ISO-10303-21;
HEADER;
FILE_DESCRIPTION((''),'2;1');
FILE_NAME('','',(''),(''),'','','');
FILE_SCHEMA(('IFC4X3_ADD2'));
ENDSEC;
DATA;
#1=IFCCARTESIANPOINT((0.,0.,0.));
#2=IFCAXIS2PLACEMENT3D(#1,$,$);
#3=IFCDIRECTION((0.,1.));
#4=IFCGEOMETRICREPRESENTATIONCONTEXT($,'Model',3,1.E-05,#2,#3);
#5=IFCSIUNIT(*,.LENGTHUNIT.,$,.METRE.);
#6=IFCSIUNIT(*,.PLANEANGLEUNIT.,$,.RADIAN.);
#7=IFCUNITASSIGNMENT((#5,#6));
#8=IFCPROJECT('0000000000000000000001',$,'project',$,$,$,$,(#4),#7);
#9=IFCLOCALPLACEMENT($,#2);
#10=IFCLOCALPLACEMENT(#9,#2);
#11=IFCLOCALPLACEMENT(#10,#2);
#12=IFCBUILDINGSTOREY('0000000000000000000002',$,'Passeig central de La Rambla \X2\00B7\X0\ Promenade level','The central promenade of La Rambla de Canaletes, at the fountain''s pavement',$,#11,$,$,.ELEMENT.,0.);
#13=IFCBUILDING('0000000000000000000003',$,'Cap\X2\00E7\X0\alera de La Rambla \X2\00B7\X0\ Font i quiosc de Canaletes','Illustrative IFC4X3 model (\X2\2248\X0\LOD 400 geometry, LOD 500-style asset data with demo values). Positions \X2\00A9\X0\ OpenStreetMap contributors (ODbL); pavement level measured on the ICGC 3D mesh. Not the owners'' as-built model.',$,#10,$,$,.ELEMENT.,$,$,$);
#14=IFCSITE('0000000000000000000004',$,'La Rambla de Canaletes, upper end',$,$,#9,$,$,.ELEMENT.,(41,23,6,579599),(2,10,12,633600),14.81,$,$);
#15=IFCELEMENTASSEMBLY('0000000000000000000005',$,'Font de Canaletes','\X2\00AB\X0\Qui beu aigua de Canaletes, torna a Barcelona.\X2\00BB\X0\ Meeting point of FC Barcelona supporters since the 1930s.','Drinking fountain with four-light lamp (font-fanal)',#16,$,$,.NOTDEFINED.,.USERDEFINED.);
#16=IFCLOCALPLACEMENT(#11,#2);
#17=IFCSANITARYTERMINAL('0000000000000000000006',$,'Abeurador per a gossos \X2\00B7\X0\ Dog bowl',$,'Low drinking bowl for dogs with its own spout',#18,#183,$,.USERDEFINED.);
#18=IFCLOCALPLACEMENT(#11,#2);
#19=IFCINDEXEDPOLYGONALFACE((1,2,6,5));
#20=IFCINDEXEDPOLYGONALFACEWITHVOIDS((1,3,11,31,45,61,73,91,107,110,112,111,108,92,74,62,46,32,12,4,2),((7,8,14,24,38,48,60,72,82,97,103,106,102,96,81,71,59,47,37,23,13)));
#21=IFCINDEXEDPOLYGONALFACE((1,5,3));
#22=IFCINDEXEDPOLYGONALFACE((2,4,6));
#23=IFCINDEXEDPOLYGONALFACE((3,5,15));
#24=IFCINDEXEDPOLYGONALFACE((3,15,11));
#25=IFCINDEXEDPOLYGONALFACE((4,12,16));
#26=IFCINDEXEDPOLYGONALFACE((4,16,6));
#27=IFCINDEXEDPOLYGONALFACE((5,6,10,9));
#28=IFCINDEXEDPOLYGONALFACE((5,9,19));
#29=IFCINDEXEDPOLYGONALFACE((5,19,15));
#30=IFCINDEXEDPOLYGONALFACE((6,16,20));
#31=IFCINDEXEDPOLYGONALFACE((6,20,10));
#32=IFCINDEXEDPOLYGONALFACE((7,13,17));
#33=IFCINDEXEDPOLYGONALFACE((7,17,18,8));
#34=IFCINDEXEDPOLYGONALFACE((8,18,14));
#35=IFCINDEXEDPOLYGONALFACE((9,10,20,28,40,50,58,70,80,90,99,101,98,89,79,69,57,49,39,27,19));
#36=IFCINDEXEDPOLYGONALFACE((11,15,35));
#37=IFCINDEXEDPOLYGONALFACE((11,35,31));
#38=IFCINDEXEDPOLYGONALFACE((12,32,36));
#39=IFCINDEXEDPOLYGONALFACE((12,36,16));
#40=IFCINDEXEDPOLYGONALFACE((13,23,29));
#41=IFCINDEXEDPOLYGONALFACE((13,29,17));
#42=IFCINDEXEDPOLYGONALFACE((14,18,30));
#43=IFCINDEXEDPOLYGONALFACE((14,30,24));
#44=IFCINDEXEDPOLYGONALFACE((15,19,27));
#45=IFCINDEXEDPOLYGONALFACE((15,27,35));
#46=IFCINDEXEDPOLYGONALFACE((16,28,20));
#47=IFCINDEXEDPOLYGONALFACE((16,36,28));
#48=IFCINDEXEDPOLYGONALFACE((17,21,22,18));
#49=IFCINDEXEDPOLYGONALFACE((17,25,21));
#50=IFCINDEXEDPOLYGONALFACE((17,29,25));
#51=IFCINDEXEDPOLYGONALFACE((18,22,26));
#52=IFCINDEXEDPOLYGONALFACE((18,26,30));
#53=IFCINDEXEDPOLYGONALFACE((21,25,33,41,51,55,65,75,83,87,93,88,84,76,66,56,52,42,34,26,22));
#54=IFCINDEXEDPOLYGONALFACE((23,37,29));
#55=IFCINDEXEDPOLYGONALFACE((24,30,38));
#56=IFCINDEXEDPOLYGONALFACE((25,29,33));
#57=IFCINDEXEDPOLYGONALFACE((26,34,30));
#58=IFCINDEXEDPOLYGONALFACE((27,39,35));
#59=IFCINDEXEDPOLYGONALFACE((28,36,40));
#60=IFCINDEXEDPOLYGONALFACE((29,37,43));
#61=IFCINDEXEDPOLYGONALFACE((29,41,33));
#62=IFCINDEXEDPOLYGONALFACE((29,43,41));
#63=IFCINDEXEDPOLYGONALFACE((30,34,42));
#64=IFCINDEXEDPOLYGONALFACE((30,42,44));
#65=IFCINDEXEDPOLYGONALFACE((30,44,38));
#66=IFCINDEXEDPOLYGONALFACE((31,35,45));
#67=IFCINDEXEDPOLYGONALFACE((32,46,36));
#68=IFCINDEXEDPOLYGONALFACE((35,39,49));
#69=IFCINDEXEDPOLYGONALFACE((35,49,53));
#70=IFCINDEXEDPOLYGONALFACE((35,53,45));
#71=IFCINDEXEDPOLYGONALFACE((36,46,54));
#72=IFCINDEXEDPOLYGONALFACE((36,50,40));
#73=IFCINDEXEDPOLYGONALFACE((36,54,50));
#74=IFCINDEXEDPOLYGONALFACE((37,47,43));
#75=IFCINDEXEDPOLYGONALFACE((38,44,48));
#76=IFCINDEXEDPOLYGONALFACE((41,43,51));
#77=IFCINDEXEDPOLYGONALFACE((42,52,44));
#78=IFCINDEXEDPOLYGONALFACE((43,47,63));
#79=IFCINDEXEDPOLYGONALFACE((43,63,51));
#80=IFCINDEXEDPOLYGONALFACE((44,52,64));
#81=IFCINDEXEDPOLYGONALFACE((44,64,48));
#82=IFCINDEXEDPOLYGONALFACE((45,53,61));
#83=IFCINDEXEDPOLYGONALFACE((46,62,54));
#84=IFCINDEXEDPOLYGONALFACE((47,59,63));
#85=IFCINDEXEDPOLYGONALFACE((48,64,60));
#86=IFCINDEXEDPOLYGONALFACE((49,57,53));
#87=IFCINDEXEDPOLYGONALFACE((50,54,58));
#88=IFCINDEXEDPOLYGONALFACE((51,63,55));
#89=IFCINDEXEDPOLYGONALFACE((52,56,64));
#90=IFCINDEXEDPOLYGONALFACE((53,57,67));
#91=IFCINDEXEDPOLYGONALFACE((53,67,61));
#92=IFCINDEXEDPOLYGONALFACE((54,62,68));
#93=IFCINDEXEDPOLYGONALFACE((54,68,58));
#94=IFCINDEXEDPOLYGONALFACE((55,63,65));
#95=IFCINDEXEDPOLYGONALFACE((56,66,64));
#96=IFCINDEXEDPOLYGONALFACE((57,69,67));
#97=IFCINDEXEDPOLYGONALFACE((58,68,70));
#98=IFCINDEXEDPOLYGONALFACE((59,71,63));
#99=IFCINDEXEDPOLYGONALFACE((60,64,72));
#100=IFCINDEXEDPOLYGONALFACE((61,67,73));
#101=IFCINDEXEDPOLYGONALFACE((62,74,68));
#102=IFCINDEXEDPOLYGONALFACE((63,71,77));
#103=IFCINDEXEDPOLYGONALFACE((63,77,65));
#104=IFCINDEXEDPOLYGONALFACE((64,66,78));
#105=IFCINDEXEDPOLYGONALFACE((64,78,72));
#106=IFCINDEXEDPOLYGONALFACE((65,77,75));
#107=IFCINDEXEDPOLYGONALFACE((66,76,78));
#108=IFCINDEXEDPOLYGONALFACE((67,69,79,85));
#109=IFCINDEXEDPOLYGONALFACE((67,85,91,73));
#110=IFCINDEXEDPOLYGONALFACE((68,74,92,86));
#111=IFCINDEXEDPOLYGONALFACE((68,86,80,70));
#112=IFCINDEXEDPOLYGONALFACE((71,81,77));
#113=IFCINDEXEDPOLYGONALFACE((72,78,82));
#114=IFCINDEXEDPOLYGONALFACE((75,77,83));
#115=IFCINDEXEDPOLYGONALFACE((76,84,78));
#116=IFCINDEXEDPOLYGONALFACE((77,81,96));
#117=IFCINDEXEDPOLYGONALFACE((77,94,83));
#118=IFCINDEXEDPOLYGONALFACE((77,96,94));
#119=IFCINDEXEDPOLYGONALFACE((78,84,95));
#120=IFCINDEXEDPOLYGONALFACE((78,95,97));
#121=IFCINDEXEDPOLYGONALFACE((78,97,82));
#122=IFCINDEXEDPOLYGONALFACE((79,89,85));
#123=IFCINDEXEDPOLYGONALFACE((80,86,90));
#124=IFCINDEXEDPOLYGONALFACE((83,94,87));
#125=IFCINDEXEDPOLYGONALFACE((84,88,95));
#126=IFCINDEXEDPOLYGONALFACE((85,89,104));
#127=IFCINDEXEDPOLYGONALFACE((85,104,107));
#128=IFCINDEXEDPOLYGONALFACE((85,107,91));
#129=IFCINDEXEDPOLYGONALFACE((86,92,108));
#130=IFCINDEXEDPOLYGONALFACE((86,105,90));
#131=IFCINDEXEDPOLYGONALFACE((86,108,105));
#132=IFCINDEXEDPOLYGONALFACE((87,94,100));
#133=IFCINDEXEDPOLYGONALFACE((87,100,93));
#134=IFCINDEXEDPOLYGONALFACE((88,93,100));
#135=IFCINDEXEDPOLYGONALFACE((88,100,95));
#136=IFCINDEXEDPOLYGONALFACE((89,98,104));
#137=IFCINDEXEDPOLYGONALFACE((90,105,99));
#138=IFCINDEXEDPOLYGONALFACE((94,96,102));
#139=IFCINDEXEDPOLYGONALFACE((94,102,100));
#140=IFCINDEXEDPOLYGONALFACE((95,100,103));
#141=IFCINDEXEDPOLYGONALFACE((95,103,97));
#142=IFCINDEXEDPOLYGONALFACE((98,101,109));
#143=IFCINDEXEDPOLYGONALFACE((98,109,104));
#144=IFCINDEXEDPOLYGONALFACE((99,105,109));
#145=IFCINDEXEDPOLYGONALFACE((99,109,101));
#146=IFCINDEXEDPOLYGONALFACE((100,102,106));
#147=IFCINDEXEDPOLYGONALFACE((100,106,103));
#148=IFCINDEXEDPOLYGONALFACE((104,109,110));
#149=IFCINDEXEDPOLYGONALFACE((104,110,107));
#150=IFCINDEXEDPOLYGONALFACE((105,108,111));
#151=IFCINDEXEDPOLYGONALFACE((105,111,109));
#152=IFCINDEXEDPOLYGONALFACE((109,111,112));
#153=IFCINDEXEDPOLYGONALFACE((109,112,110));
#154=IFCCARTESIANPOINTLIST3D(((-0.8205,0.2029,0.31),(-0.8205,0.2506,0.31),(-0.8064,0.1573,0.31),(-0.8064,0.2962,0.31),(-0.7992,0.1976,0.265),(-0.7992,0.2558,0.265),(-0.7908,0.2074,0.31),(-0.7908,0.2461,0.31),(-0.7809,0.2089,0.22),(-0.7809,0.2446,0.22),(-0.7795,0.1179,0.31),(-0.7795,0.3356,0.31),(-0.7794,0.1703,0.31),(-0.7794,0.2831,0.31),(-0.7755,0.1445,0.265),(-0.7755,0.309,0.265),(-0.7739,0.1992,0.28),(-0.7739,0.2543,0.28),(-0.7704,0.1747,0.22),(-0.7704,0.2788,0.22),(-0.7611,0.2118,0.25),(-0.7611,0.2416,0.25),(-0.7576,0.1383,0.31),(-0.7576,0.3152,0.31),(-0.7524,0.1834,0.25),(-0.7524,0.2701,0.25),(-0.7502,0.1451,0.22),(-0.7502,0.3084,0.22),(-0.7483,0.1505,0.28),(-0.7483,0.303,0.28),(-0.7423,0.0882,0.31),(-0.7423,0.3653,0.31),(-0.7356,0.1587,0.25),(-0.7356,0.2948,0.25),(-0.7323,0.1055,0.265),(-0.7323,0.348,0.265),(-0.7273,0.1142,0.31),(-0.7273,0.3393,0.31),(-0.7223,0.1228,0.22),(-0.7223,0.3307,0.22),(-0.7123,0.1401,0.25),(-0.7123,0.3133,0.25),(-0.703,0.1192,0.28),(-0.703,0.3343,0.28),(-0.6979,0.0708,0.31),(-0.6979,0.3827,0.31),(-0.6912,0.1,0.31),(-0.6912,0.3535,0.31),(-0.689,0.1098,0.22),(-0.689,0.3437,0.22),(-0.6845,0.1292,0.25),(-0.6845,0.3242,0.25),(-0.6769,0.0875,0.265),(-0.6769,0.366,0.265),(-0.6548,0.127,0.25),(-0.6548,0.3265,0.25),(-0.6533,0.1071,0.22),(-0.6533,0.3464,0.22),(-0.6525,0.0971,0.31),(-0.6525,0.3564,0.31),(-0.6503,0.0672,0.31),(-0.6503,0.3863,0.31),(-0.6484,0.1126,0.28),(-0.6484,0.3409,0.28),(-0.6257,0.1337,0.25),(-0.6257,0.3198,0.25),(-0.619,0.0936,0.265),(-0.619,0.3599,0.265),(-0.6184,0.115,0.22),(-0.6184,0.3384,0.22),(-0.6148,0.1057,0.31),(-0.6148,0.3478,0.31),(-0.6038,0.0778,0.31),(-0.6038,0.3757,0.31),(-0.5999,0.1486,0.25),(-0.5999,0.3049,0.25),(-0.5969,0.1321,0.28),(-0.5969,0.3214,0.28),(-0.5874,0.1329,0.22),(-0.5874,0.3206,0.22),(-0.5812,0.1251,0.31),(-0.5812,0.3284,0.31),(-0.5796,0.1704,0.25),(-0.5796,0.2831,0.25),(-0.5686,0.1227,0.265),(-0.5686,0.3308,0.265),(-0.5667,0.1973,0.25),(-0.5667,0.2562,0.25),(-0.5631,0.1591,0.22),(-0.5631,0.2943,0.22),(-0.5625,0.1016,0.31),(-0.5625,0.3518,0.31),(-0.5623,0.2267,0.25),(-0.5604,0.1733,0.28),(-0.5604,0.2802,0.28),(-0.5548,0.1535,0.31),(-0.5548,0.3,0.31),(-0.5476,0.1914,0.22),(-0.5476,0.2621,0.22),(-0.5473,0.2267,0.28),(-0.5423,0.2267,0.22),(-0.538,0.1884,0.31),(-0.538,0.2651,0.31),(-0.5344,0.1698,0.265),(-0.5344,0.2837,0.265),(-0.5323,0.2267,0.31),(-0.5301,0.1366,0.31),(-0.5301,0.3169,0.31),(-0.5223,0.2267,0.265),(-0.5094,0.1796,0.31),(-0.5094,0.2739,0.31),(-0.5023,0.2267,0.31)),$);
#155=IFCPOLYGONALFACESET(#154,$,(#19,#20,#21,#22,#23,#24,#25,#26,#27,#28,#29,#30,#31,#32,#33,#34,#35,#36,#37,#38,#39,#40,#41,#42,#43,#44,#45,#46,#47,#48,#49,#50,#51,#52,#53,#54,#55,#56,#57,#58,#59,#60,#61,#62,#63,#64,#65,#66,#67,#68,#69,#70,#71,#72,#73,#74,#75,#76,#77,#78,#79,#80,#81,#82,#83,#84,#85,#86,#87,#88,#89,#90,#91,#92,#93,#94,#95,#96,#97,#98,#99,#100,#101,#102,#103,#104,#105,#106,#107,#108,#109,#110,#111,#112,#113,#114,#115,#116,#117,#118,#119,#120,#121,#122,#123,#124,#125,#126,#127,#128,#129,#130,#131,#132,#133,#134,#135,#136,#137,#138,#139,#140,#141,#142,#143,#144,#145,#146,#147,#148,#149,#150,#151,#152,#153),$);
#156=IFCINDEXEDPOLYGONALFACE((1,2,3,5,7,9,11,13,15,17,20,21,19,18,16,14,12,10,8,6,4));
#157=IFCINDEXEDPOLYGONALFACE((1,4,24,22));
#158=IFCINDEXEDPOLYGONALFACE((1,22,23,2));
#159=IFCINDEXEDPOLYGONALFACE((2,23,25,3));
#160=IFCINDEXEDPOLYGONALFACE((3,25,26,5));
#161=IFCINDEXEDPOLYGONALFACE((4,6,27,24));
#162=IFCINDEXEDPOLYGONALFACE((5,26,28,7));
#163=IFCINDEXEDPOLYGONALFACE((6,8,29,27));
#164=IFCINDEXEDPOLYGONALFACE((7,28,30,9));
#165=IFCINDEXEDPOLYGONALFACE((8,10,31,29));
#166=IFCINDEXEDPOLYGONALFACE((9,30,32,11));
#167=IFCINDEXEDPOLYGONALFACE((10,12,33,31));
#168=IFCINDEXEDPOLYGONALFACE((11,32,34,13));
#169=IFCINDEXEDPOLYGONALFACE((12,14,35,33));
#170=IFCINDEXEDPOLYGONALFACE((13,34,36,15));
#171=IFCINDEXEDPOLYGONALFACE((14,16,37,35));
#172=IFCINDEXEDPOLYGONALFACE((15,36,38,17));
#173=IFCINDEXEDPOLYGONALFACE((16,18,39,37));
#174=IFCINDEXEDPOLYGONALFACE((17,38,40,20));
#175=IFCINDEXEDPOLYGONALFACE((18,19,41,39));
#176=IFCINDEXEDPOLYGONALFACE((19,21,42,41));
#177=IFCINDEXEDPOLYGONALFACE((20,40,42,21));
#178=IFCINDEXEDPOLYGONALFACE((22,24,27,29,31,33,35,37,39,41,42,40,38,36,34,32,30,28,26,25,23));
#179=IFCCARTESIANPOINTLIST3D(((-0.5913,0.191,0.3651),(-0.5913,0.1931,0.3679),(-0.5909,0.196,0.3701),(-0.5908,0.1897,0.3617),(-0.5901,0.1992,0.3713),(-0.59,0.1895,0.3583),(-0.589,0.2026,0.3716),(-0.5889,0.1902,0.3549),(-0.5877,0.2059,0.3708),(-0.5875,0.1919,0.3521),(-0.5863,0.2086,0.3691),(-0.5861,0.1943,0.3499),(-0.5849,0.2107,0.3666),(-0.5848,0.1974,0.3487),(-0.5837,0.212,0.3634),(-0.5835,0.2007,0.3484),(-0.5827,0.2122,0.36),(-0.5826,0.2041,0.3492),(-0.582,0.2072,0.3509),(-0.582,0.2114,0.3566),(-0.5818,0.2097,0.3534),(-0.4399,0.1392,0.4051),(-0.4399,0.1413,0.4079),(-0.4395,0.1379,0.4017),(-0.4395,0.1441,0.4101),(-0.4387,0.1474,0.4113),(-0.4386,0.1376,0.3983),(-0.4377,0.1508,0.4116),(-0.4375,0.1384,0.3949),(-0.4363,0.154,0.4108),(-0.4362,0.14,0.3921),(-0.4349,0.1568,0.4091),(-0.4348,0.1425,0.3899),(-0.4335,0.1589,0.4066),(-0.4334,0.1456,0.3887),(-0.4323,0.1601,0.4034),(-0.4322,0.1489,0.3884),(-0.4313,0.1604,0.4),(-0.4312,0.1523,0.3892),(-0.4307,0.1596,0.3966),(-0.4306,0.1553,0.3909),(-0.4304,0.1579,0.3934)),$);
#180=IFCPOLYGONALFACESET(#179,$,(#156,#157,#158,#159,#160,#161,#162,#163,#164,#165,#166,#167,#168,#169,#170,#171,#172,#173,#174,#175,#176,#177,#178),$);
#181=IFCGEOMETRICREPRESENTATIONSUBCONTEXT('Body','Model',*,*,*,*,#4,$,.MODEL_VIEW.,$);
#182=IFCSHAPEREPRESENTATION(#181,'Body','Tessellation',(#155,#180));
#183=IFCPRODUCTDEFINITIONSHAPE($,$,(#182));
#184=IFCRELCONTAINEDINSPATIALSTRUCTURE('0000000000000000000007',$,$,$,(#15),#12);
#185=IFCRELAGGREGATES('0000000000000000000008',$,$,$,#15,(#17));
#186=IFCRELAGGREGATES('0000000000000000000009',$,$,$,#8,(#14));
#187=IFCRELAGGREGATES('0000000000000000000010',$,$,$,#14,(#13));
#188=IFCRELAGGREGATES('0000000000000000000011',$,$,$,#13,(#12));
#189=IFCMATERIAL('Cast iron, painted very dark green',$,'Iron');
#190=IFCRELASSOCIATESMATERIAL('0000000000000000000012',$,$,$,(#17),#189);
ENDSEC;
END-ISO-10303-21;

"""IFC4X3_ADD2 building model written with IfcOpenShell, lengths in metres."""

from ifc_helpers import new_model, entity, si_unit, direction, frame, origin, origin_2d_with_axis, place, context, subcontext, project, spatial, circle, extrude, material, element, aggregate, save


model = new_model("IFC4X3_ADD2")

# Units and contexts
model_context = context("Model", 3, precision=1e-05, world=origin(), true_north=direction((0.0, 1.0)))
body_context = subcontext(model_context, "Body", "Model", "MODEL_VIEW")
ifc_project = project(units=[si_unit("LENGTHUNIT", "METRE"), si_unit("PLANEANGLEUNIT", "RADIAN")], contexts=[model_context])

# Site, building, storey
site_placement = place(None, origin())
site = spatial("IfcSite", under=ifc_project, at=site_placement, Name="La Rambla de Canaletes, upper end", CompositionType="ELEMENT", RefLatitude=(41, 23, 6, 579599), RefLongitude=(2, 10, 12, 633600), RefElevation=14.81)
building_placement = place(site_placement, origin())
building = spatial("IfcBuilding", under=site, at=building_placement, Name="Capçalera de La Rambla · Font i quiosc de Canaletes", Description="Illustrative IFC4X3 model (≈LOD 400 geometry, LOD 500-style asset data with demo values). Positions © OpenStreetMap contributors (ODbL); pavement level measured on the ICGC 3D mesh. Not the owners' as-built model.", CompositionType="ELEMENT")
storey_placement = place(building_placement, origin())
storey = spatial("IfcBuildingStorey", under=building, at=storey_placement, Name="Passeig central de La Rambla · Promenade level", Description="The central promenade of La Rambla de Canaletes, at the fountain's pavement", CompositionType="ELEMENT", Elevation=0.0)

# Element assembly, sanitary terminal
assembly_1_placement = place(building_placement, origin())
assembly_1 = element("IfcElementAssembly", 1, at=assembly_1_placement, inside=storey, Name="Font de Canaletes", Description="«Qui beu aigua de Canaletes, torna a Barcelona.» Meeting point of FC Barcelona supporters since the 1930s.", ObjectType="Drinking fountain with four-light lamp (font-fanal)", AssemblyPlace="NOTDEFINED", PredefinedType="USERDEFINED")
ifc_material_1 = material(Name="Cast iron, painted very dark green", Category="Iron")
sanitary_terminal_1_placement = place(building_placement, origin())
sanitary_terminal_1 = element("IfcSanitaryTerminal", 2, at=sanitary_terminal_1_placement, material=ifc_material_1, Name="Abeurador per a gossos · Dog bowl", ObjectType="Low drinking bowl for dogs with its own spout", PredefinedType="USERDEFINED", context=body_context, shape_type="SweptSolid", body=[
    entity("IfcRevolvedAreaSolid", entity("IfcArbitraryClosedProfileDef", "AREA", None, entity("IfcPolyline", [entity("IfcCartesianPoint", [0.0, 0.0]), entity("IfcCartesianPoint", [0.12, 0.0]), entity("IfcCartesianPoint", [0.16, 0.09]), entity("IfcCartesianPoint", [0.13, 0.09]), entity("IfcCartesianPoint", [0.1, 0.03]), entity("IfcCartesianPoint", [0.0, 0.03]), entity("IfcCartesianPoint", [0.0, 0.0])])), entity("IfcAxis2Placement3D", entity("IfcCartesianPoint", [-0.6623, 0.2267, 0.22]), entity("IfcDirection", [0.0, -1.0, 0.0]), entity("IfcDirection", [1.0, 0.0, 0.0])), entity("IfcAxis1Placement", entity("IfcCartesianPoint", [0.0, 0.0, 0.0]), entity("IfcDirection", [0.0, 1.0, 0.0])), 6.283185),
    extrude(circle(Radius=0.012, at=origin_2d_with_axis()), frame((-0.4352, 0.149, 0.4), z_axis=(-0.917838, 0.314246, -0.242536), x_axis=(0.323917, 0.946085, 0.0)), (0.0, 0.0, 1.0), 0.1649),
])
aggregate(assembly_1, [sanitary_terminal_1])

save(model, "model.ifc")
